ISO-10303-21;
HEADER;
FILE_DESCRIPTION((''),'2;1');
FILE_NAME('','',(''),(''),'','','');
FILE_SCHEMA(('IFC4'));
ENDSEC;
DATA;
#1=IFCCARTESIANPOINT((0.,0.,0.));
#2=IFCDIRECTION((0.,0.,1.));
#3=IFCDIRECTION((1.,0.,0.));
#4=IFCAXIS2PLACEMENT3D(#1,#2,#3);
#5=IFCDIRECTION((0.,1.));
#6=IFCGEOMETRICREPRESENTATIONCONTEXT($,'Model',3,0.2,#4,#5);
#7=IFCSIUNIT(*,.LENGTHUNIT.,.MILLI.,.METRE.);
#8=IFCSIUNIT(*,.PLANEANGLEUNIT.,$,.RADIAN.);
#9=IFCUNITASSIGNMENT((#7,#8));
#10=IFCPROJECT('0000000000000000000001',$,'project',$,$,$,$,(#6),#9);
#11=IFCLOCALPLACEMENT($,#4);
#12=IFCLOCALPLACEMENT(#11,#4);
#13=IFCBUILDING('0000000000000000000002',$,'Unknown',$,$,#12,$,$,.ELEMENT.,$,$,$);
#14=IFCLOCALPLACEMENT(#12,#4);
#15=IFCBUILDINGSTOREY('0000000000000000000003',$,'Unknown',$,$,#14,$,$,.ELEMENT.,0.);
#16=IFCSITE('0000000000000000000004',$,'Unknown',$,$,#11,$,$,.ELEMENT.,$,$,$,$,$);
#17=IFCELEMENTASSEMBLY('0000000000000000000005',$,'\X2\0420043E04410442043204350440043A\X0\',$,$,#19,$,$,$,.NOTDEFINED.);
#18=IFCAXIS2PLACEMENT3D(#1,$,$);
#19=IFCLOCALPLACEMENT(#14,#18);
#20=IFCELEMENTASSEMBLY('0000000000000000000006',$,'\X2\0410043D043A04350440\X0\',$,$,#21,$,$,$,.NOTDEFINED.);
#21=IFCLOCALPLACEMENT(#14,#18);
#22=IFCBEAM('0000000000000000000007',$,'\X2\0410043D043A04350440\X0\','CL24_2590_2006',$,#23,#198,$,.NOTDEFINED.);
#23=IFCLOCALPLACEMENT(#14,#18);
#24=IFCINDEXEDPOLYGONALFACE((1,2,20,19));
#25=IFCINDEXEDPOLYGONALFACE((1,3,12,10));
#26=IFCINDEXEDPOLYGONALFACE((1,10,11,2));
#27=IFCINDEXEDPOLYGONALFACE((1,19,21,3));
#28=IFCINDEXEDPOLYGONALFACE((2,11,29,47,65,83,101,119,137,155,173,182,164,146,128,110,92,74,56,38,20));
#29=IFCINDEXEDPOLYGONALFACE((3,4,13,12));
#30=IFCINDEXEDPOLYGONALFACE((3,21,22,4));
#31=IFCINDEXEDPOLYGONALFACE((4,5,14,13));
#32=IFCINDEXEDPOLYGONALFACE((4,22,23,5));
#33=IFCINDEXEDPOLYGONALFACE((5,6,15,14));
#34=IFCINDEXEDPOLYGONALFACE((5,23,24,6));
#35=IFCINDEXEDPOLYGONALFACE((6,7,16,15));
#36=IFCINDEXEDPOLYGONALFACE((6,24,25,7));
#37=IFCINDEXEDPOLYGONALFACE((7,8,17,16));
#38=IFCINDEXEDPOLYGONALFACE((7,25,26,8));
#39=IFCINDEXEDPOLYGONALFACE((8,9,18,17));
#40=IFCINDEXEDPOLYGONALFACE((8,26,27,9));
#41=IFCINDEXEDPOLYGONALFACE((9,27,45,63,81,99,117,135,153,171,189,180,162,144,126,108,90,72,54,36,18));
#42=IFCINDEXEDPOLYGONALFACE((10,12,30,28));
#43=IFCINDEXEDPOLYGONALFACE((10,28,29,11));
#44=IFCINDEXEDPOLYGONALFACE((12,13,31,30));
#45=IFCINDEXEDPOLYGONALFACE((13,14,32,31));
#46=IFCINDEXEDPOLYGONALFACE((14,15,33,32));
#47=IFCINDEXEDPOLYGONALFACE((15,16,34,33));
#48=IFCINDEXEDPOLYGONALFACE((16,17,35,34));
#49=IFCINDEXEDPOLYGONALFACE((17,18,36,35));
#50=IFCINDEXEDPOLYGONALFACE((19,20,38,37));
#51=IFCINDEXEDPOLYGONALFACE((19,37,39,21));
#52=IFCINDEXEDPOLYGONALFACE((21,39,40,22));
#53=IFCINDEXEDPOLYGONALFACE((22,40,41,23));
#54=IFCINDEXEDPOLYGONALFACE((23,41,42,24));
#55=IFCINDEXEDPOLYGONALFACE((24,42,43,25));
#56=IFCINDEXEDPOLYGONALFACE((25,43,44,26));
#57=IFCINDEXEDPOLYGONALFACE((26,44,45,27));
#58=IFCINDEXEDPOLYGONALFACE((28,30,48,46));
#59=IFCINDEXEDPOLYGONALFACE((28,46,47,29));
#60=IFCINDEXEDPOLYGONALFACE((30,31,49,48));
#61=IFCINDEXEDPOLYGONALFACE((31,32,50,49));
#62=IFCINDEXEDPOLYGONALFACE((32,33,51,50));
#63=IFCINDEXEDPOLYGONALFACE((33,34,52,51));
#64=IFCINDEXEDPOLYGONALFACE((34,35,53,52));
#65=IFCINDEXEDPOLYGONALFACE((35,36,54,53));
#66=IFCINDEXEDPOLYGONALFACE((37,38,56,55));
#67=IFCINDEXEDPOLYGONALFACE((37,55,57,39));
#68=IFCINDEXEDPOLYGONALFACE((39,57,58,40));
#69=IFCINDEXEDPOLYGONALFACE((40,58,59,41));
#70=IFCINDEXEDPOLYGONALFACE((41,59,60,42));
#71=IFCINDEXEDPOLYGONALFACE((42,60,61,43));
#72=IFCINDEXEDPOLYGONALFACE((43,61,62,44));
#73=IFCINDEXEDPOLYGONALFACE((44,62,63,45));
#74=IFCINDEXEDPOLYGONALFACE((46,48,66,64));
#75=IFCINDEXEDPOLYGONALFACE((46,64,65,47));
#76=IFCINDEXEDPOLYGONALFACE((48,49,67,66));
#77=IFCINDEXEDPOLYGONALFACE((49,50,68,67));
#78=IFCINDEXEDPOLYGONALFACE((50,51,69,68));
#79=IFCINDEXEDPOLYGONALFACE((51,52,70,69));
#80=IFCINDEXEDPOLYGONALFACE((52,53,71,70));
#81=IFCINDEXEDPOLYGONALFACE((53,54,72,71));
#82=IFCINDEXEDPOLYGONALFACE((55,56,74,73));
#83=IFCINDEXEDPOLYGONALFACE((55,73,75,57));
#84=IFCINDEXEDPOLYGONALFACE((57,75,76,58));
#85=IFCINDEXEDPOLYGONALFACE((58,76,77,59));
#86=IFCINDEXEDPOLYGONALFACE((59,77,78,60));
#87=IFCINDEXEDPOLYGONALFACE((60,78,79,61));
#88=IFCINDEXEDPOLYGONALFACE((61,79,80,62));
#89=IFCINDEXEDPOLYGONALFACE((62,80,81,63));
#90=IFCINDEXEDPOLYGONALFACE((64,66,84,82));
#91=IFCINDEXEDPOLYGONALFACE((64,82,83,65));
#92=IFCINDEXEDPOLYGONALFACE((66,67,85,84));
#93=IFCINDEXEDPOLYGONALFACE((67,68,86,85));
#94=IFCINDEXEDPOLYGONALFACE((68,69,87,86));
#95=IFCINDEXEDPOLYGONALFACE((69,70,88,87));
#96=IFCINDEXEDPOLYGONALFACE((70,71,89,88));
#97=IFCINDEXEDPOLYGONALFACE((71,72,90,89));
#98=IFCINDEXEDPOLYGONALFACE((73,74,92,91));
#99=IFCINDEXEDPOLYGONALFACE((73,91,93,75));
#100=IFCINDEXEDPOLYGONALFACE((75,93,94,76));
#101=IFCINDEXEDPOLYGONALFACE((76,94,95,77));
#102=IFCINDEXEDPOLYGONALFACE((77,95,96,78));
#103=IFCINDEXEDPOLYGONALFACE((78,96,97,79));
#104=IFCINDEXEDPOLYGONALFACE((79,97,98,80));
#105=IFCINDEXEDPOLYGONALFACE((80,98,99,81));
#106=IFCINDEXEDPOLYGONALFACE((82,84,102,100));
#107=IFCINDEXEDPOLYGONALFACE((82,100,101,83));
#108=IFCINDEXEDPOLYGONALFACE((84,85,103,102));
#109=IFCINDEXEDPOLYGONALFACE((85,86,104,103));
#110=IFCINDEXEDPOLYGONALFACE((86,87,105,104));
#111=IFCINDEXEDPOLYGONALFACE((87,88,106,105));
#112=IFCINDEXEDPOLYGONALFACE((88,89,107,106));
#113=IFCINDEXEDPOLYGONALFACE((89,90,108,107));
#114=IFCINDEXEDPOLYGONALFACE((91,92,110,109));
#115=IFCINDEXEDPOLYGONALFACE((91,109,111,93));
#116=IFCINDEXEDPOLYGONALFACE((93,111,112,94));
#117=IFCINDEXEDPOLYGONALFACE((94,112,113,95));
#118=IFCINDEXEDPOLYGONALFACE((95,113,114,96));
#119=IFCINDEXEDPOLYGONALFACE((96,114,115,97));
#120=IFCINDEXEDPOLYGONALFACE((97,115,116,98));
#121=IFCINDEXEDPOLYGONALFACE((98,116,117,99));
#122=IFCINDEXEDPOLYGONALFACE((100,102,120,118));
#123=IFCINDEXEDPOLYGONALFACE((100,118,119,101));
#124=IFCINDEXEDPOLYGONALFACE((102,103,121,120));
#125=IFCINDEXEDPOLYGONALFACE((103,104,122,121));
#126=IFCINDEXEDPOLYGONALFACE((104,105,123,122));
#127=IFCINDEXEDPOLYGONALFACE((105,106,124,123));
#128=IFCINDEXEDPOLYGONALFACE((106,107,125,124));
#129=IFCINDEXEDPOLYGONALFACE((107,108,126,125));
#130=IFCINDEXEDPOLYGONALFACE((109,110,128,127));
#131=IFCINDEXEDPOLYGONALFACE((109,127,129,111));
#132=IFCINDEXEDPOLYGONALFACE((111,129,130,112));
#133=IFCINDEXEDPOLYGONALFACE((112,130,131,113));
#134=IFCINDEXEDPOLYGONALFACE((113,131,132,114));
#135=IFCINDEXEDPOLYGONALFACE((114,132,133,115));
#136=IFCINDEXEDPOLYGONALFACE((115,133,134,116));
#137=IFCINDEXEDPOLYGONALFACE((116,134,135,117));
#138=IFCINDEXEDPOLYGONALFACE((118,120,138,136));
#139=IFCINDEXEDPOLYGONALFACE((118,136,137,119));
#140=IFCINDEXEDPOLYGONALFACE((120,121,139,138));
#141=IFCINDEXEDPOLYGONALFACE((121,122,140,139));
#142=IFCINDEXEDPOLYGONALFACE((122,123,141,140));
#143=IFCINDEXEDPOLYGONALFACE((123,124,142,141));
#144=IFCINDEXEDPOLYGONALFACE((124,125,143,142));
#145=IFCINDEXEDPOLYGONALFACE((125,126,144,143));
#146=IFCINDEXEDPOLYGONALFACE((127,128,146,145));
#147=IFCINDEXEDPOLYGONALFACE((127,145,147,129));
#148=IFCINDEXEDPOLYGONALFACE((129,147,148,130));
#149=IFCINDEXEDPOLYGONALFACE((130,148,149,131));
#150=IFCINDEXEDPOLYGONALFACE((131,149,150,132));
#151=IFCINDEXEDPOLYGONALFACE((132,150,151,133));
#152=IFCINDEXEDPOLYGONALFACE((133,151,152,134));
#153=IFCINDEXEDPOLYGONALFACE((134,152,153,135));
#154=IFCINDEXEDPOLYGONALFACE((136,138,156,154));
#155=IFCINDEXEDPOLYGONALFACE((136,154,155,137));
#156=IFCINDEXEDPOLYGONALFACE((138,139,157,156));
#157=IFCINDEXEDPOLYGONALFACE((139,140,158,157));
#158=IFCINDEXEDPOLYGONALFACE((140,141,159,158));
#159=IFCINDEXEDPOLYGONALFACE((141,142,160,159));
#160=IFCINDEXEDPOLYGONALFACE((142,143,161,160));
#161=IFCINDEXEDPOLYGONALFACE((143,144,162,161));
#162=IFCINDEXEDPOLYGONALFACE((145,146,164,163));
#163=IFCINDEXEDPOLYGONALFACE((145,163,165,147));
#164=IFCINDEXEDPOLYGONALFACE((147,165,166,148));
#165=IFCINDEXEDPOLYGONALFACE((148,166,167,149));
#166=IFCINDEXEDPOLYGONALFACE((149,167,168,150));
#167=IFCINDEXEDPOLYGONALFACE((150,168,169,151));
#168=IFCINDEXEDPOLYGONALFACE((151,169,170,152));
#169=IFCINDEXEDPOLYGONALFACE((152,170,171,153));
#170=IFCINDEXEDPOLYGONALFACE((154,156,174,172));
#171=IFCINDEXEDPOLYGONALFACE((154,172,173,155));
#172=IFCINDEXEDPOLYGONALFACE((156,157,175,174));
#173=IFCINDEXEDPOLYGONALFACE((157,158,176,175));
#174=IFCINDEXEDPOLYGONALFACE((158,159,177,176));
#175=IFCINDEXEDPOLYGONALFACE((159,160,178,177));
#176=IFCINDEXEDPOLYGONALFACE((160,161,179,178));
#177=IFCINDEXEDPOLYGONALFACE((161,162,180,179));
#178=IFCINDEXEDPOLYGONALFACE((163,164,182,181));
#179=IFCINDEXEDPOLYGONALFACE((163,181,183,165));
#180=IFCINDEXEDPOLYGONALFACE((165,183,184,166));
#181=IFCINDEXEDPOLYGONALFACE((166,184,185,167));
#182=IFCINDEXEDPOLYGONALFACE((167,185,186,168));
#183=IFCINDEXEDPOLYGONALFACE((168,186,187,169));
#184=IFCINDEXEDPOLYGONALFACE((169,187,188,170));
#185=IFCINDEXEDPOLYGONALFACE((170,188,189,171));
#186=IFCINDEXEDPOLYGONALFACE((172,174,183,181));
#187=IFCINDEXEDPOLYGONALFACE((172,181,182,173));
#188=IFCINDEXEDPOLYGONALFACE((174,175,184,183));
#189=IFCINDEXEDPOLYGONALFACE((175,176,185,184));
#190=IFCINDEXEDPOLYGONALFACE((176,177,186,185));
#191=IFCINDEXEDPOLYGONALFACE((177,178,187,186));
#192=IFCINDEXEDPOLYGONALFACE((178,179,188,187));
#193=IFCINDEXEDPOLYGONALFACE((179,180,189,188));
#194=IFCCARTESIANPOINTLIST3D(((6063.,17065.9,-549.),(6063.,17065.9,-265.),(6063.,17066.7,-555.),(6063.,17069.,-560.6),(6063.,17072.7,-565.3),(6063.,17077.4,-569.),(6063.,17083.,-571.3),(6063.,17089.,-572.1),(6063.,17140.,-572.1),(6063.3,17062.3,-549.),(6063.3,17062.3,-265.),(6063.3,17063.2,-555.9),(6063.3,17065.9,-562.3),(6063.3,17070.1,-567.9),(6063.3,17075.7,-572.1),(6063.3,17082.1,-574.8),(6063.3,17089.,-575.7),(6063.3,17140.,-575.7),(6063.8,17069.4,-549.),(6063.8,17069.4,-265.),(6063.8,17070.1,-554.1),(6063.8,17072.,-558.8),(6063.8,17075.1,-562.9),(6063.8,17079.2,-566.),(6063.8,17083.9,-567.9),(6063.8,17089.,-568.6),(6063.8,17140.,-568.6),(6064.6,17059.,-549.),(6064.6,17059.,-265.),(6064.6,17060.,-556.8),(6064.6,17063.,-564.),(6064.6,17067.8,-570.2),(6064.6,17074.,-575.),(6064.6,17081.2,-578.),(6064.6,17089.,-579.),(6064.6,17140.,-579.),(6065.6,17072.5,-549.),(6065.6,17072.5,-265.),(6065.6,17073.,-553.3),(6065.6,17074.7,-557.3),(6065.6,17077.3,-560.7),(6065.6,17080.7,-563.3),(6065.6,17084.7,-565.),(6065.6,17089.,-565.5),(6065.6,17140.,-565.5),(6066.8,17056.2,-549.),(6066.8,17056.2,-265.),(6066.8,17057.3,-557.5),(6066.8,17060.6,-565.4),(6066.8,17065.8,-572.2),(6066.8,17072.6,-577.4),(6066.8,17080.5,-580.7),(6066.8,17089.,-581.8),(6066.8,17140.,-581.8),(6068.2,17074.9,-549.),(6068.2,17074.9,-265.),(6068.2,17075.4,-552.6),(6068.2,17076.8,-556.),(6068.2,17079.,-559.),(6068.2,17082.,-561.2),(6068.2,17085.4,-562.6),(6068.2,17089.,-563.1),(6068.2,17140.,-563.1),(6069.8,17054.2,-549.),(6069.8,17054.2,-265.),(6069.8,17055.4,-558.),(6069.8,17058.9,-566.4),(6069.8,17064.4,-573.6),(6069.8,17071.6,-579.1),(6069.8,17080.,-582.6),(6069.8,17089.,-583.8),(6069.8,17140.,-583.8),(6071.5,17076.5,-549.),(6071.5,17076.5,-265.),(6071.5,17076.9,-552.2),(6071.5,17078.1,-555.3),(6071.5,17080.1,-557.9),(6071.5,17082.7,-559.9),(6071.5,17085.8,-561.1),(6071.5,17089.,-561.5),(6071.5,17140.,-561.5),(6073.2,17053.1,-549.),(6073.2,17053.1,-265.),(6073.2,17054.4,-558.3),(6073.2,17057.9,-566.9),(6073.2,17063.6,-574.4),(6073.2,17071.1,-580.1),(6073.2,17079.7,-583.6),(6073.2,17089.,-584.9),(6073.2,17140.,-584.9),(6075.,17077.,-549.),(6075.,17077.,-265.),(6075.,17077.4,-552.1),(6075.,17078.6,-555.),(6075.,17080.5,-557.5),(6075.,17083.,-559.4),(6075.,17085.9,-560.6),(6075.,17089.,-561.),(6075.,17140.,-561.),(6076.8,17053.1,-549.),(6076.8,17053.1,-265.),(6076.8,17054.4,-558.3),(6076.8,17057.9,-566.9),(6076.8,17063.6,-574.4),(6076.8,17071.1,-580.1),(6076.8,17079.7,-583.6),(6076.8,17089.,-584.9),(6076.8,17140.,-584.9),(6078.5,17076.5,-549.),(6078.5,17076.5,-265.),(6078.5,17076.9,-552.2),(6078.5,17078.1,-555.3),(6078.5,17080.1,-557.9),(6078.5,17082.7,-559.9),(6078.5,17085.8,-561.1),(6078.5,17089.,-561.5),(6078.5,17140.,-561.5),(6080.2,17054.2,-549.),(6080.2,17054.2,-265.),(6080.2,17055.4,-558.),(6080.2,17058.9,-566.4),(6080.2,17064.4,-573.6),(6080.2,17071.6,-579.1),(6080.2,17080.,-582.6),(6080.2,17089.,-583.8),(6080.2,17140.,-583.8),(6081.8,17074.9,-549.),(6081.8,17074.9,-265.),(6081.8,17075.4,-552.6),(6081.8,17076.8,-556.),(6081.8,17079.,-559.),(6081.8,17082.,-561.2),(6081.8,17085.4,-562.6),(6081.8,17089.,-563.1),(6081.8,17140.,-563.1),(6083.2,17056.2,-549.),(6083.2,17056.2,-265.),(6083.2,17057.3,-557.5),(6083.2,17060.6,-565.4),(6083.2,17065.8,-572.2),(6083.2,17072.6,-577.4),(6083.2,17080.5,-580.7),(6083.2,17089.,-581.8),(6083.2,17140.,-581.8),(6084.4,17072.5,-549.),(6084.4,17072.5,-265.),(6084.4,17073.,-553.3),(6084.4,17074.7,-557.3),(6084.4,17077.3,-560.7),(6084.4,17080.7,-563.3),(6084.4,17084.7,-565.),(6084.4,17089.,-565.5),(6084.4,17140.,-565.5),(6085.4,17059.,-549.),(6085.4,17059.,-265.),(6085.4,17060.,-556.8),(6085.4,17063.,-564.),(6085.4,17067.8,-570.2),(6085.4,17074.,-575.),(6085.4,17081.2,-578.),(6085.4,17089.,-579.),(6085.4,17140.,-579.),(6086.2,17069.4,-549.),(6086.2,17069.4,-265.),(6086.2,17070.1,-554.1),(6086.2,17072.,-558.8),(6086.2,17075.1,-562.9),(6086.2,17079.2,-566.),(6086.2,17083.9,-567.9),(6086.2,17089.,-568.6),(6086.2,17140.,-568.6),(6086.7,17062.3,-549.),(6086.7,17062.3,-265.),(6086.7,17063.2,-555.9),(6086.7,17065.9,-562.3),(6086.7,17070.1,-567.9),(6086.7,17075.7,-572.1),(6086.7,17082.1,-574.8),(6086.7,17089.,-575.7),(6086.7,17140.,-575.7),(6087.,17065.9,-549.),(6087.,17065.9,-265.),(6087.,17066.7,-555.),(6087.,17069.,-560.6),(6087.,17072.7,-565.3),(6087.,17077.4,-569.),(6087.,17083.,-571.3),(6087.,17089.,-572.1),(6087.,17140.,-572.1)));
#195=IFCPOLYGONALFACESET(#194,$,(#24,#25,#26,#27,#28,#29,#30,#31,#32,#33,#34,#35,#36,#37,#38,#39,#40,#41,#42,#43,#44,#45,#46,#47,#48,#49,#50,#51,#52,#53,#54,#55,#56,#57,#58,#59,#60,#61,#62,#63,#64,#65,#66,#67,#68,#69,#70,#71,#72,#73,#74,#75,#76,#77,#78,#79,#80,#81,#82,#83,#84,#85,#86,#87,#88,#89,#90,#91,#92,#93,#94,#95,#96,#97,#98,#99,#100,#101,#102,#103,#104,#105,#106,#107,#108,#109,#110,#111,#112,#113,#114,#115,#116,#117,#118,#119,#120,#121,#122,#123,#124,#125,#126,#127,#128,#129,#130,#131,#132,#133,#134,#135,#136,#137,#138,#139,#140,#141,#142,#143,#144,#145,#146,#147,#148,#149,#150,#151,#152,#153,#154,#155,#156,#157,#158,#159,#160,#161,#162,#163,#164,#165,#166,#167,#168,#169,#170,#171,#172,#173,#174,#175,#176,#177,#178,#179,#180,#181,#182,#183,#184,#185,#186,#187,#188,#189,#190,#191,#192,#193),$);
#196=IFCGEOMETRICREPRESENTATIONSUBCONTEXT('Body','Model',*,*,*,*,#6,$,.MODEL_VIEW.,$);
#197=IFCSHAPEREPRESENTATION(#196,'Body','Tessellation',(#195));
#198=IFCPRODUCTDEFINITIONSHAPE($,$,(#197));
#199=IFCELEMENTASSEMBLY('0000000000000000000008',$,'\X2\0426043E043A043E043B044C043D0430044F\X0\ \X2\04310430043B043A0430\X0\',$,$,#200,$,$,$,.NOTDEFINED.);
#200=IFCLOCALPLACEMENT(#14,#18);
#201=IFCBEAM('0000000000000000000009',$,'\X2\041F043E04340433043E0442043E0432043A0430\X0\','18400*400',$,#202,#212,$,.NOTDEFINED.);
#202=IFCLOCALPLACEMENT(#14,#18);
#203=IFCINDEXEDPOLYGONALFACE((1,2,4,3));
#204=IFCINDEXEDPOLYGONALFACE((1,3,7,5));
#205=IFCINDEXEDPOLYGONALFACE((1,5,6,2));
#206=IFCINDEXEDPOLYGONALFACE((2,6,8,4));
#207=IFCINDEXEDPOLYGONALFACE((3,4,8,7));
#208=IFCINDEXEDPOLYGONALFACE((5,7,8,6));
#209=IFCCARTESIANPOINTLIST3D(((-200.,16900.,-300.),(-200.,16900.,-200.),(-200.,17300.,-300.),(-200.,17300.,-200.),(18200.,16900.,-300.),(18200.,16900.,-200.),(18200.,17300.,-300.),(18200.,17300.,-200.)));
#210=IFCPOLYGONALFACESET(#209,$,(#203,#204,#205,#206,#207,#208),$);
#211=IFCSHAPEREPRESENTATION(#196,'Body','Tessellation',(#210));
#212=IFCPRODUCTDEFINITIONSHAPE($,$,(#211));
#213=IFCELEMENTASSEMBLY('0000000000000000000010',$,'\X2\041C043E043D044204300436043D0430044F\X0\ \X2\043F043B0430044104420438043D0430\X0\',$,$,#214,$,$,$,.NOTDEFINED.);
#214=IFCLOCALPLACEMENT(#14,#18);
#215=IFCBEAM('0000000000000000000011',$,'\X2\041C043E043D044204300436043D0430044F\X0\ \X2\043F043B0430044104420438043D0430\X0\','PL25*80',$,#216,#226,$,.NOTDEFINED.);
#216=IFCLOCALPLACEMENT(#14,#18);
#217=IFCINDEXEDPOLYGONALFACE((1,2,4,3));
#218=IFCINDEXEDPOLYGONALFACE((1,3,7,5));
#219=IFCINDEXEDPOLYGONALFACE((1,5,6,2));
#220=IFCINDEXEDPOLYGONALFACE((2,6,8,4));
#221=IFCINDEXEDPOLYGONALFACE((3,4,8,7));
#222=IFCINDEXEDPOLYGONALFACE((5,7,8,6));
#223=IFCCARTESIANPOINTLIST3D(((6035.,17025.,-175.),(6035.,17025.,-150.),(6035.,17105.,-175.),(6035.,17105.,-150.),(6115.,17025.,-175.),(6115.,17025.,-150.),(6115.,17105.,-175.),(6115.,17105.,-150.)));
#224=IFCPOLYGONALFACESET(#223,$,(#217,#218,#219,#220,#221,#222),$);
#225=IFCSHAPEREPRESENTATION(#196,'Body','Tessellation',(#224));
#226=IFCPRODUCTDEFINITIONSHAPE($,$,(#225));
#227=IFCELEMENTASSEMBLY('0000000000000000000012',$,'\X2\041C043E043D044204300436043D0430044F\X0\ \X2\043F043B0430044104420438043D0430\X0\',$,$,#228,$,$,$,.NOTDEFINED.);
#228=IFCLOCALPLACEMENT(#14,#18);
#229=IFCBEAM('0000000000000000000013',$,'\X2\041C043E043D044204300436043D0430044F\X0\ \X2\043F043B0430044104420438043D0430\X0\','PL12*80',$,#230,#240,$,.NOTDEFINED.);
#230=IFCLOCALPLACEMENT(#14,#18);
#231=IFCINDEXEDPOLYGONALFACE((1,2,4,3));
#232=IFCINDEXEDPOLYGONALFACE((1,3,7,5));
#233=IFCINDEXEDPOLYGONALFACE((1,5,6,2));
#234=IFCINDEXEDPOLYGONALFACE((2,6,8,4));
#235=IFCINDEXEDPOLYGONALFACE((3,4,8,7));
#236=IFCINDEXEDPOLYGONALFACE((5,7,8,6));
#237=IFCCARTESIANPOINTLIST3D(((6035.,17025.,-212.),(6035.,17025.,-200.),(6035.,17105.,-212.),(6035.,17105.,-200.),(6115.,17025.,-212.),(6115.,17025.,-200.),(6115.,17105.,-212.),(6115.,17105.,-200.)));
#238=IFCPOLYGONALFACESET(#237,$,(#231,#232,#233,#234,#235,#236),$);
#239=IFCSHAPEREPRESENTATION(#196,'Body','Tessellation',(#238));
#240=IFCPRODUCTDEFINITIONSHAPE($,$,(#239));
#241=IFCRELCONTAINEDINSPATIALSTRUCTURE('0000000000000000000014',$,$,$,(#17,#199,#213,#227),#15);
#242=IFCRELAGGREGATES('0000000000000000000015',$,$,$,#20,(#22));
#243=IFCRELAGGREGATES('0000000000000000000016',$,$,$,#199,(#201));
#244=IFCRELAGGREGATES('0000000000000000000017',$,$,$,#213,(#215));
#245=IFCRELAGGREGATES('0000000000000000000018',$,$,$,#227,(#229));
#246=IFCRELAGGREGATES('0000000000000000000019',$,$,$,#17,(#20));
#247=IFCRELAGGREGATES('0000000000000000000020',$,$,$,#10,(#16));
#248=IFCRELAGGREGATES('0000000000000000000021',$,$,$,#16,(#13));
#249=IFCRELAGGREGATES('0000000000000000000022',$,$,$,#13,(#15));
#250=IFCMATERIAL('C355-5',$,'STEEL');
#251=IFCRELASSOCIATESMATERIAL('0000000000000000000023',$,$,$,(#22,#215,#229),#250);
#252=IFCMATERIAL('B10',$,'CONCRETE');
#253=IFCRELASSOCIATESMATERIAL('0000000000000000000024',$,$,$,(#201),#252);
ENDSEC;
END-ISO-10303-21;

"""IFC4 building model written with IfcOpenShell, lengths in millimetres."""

from ifc_helpers import new_model, entity, si_unit, direction, frame, origin_with_axes, place, context, subcontext, project, spatial, line, indexed_curve, outline, extrude, material, element, aggregate, save


model = new_model("IFC4")

# Units and contexts
model_context = context("Model", 3, precision=0.2, world=origin_with_axes(), true_north=direction((0.0, 1.0)))
body_context = subcontext(model_context, "Body", "Model", "MODEL_VIEW")
ifc_project = project(units=[si_unit("LENGTHUNIT", "METRE", prefix="MILLI"), si_unit("PLANEANGLEUNIT", "RADIAN")], contexts=[model_context])

# Site, building, storey
site_placement = place(None, origin_with_axes())
site = spatial("IfcSite", under=ifc_project, at=site_placement, Name="Unknown", CompositionType="ELEMENT")
building_placement = place(site_placement, origin_with_axes())
building = spatial("IfcBuilding", under=site, at=building_placement, Name="Unknown", CompositionType="ELEMENT")
storey_placement = place(building_placement, origin_with_axes())
storey = spatial("IfcBuildingStorey", under=building, at=storey_placement, Name="Unknown", CompositionType="ELEMENT", Elevation=0.0)

# Element assembly
assembly_1_placement = place(storey_placement, frame((6000.0, 16827.0, -300.0), z_axis=(-1.0, 0.0, 0.0), x_axis=(0.0, 0.0, -1.0)))
assembly_1 = element("IfcElementAssembly", 1, at=assembly_1_placement, inside=storey, Name="Ростверк", PredefinedType="NOTDEFINED")

# Shared definitions
ifc_material_1 = material(Name="B10", Category="CONCRETE")

# Element assembly, beam, voiding feature
assembly_2_placement = place(assembly_1_placement, frame((-215.0, -238.0, -75.0), z_axis=(0.0, -1.0, 0.0), x_axis=(1.0, 0.0, 0.0)))
assembly_2 = element("IfcElementAssembly", 2, at=assembly_2_placement, Name="Анкер", PredefinedType="NOTDEFINED")
ifc_material_2 = material(Name="C355-5", Category="STEEL")
beam_1_placement = place(assembly_2_placement, origin_with_axes())
beam_1 = element("IfcBeam", 3, at=beam_1_placement, material=ifc_material_2, Name="Анкер", Description="CL24_2590_2006", PredefinedType="NOTDEFINED", context=body_context, shape_type="SolidModel", body=[
    entity("IfcSweptDiskSolid", entity("IfcIndexedPolyCurve", entity("IfcCartesianPointList3D", [[0.0, 0.0, 0.0], [464.0, 0.0, 0.0], [481.0, 0.0, 7.0], [488.0, 0.0, 24.0], [488.0, 0.0, 75.0]]), [entity("IfcLineIndex", [1, 2]), entity("IfcArcIndex", [2, 3, 4]), entity("IfcLineIndex", [4, 5])]), 12.0),
])
voiding_feature_placement = place(beam_1_placement, frame((0.0, 0.0, 0.0), z_axis=(0.0, -1.0, 0.0), x_axis=(1.0, 0.0, 0.0)))
element("IfcVoidingFeature", 4, at=voiding_feature_placement, cuts=beam_1, Name="Анкер", PredefinedType="HOLE", context=body_context, shape_type="SolidModel", body=[
    extrude(outline(indexed_curve([(12.5, 0.0), (12.2, 2.8), (11.3, 5.4), (9.8, 7.8), (7.8, 9.8), (5.4, 11.3), (2.8, 12.2), (0.0, 12.5), (-2.8, 12.2), (-5.4, 11.3), (-7.8, 9.8), (-9.8, 7.8), (-11.3, 5.4), (-12.2, 2.8), (-12.5, 0.0), (-12.2, -2.8), (-11.3, -5.4), (-9.8, -7.8), (-7.8, -9.8), (-5.4, -11.3), (-2.8, -12.2), (0.0, -12.5), (2.8, -12.2), (5.4, -11.3), (7.8, -9.8), (9.8, -7.8), (11.3, -5.4), (12.2, -2.8)], segments=[line(1, 2, 3, 4, 5, 6, 7, 8, 9, 10, 11, 12, 13, 14, 15, 16, 17, 18, 19, 20, 21, 22, 23, 24, 25, 26, 27, 28, 1)])), frame((0.0, 0.0, 0.0), z_axis=(-1.0, 0.0, 0.0), x_axis=(0.0, 0.0, 1.0)), (0.0, 0.0, -1.0), 180.0),
])
aggregate(assembly_2, [beam_1])

# Element assemblies, beams
assembly_3_placement = place(storey_placement, frame((18200.0, 17100.0, 100.0), z_axis=(0.0, 1.0, 0.0), x_axis=(-1.0, 0.0, 0.0)))
assembly_3 = element("IfcElementAssembly", 5, at=assembly_3_placement, inside=storey, Name="Цокольная балка", PredefinedType="NOTDEFINED")
beam_2_placement = place(assembly_3_placement, frame((9200.0, -300.0, 0.0), z_axis=(0.0, 0.0, -1.0), x_axis=(0.0, -1.0, 0.0)))
beam_2 = element("IfcBeam", 6, at=beam_2_placement, material=ifc_material_1, Name="Подготовка", Description="18400*400", PredefinedType="NOTDEFINED", context=body_context, shape_type="SolidModel", body=[
    extrude(outline(indexed_curve([(-200.0, -9200.0), (200.0, -9200.0), (200.0, 9200.0), (-200.0, 9200.0)], segments=[line(1, 2, 3, 4, 1)])), frame((0.0, 0.0, 0.0), z_axis=(-1.0, 0.0, 0.0), x_axis=(0.0, 0.0, 1.0)), (0.0, 0.0, -1.0), 100.0),
])
aggregate(assembly_3, [beam_2])
assembly_4_placement = place(storey_placement, frame((6115.0, 17065.0, -162.5), z_axis=(0.0, 0.0, -1.0), x_axis=(-1.0, 0.0, 0.0)))
assembly_4 = element("IfcElementAssembly", 7, at=assembly_4_placement, inside=storey, Name="Монтажная пластина", PredefinedType="NOTDEFINED")
beam_3_placement = place(assembly_4_placement, origin_with_axes())
beam_3 = element("IfcBeam", 8, at=beam_3_placement, material=ifc_material_2, Name="Монтажная пластина", Description="PL25*80", PredefinedType="NOTDEFINED", context=body_context, shape_type="SolidModel", body=[
    extrude(outline(indexed_curve([(-12.5, -40.0), (12.5, -40.0), (12.5, 40.0), (-12.5, 40.0)], segments=[line(1, 2, 3, 4, 1)])), frame((0.0, 0.0, 0.0), z_axis=(-1.0, 0.0, 0.0), x_axis=(0.0, 0.0, 1.0)), (0.0, 0.0, -1.0), 80.0),
])
aggregate(assembly_4, [beam_3])
assembly_5_placement = place(storey_placement, frame((6115.0, 17065.0, -206.0), z_axis=(0.0, 0.0, -1.0), x_axis=(-1.0, 0.0, 0.0)))
assembly_5 = element("IfcElementAssembly", 9, at=assembly_5_placement, inside=storey, Name="Монтажная пластина", PredefinedType="NOTDEFINED")
beam_4_placement = place(assembly_5_placement, origin_with_axes())
beam_4 = element("IfcBeam", 10, at=beam_4_placement, material=ifc_material_2, Name="Монтажная пластина", Description="PL12*80", PredefinedType="NOTDEFINED", context=body_context, shape_type="SolidModel", body=[
    extrude(outline(indexed_curve([(-6.0, -40.0), (6.0, -40.0), (6.0, 40.0), (-6.0, 40.0)], segments=[line(1, 2, 3, 4, 1)])), frame((0.0, 0.0, 0.0), z_axis=(-1.0, 0.0, 0.0), x_axis=(0.0, 0.0, 1.0)), (0.0, 0.0, -1.0), 80.0),
])
aggregate(assembly_5, [beam_4])

aggregate(assembly_1, [assembly_2])

save(model, "model.ifc")
